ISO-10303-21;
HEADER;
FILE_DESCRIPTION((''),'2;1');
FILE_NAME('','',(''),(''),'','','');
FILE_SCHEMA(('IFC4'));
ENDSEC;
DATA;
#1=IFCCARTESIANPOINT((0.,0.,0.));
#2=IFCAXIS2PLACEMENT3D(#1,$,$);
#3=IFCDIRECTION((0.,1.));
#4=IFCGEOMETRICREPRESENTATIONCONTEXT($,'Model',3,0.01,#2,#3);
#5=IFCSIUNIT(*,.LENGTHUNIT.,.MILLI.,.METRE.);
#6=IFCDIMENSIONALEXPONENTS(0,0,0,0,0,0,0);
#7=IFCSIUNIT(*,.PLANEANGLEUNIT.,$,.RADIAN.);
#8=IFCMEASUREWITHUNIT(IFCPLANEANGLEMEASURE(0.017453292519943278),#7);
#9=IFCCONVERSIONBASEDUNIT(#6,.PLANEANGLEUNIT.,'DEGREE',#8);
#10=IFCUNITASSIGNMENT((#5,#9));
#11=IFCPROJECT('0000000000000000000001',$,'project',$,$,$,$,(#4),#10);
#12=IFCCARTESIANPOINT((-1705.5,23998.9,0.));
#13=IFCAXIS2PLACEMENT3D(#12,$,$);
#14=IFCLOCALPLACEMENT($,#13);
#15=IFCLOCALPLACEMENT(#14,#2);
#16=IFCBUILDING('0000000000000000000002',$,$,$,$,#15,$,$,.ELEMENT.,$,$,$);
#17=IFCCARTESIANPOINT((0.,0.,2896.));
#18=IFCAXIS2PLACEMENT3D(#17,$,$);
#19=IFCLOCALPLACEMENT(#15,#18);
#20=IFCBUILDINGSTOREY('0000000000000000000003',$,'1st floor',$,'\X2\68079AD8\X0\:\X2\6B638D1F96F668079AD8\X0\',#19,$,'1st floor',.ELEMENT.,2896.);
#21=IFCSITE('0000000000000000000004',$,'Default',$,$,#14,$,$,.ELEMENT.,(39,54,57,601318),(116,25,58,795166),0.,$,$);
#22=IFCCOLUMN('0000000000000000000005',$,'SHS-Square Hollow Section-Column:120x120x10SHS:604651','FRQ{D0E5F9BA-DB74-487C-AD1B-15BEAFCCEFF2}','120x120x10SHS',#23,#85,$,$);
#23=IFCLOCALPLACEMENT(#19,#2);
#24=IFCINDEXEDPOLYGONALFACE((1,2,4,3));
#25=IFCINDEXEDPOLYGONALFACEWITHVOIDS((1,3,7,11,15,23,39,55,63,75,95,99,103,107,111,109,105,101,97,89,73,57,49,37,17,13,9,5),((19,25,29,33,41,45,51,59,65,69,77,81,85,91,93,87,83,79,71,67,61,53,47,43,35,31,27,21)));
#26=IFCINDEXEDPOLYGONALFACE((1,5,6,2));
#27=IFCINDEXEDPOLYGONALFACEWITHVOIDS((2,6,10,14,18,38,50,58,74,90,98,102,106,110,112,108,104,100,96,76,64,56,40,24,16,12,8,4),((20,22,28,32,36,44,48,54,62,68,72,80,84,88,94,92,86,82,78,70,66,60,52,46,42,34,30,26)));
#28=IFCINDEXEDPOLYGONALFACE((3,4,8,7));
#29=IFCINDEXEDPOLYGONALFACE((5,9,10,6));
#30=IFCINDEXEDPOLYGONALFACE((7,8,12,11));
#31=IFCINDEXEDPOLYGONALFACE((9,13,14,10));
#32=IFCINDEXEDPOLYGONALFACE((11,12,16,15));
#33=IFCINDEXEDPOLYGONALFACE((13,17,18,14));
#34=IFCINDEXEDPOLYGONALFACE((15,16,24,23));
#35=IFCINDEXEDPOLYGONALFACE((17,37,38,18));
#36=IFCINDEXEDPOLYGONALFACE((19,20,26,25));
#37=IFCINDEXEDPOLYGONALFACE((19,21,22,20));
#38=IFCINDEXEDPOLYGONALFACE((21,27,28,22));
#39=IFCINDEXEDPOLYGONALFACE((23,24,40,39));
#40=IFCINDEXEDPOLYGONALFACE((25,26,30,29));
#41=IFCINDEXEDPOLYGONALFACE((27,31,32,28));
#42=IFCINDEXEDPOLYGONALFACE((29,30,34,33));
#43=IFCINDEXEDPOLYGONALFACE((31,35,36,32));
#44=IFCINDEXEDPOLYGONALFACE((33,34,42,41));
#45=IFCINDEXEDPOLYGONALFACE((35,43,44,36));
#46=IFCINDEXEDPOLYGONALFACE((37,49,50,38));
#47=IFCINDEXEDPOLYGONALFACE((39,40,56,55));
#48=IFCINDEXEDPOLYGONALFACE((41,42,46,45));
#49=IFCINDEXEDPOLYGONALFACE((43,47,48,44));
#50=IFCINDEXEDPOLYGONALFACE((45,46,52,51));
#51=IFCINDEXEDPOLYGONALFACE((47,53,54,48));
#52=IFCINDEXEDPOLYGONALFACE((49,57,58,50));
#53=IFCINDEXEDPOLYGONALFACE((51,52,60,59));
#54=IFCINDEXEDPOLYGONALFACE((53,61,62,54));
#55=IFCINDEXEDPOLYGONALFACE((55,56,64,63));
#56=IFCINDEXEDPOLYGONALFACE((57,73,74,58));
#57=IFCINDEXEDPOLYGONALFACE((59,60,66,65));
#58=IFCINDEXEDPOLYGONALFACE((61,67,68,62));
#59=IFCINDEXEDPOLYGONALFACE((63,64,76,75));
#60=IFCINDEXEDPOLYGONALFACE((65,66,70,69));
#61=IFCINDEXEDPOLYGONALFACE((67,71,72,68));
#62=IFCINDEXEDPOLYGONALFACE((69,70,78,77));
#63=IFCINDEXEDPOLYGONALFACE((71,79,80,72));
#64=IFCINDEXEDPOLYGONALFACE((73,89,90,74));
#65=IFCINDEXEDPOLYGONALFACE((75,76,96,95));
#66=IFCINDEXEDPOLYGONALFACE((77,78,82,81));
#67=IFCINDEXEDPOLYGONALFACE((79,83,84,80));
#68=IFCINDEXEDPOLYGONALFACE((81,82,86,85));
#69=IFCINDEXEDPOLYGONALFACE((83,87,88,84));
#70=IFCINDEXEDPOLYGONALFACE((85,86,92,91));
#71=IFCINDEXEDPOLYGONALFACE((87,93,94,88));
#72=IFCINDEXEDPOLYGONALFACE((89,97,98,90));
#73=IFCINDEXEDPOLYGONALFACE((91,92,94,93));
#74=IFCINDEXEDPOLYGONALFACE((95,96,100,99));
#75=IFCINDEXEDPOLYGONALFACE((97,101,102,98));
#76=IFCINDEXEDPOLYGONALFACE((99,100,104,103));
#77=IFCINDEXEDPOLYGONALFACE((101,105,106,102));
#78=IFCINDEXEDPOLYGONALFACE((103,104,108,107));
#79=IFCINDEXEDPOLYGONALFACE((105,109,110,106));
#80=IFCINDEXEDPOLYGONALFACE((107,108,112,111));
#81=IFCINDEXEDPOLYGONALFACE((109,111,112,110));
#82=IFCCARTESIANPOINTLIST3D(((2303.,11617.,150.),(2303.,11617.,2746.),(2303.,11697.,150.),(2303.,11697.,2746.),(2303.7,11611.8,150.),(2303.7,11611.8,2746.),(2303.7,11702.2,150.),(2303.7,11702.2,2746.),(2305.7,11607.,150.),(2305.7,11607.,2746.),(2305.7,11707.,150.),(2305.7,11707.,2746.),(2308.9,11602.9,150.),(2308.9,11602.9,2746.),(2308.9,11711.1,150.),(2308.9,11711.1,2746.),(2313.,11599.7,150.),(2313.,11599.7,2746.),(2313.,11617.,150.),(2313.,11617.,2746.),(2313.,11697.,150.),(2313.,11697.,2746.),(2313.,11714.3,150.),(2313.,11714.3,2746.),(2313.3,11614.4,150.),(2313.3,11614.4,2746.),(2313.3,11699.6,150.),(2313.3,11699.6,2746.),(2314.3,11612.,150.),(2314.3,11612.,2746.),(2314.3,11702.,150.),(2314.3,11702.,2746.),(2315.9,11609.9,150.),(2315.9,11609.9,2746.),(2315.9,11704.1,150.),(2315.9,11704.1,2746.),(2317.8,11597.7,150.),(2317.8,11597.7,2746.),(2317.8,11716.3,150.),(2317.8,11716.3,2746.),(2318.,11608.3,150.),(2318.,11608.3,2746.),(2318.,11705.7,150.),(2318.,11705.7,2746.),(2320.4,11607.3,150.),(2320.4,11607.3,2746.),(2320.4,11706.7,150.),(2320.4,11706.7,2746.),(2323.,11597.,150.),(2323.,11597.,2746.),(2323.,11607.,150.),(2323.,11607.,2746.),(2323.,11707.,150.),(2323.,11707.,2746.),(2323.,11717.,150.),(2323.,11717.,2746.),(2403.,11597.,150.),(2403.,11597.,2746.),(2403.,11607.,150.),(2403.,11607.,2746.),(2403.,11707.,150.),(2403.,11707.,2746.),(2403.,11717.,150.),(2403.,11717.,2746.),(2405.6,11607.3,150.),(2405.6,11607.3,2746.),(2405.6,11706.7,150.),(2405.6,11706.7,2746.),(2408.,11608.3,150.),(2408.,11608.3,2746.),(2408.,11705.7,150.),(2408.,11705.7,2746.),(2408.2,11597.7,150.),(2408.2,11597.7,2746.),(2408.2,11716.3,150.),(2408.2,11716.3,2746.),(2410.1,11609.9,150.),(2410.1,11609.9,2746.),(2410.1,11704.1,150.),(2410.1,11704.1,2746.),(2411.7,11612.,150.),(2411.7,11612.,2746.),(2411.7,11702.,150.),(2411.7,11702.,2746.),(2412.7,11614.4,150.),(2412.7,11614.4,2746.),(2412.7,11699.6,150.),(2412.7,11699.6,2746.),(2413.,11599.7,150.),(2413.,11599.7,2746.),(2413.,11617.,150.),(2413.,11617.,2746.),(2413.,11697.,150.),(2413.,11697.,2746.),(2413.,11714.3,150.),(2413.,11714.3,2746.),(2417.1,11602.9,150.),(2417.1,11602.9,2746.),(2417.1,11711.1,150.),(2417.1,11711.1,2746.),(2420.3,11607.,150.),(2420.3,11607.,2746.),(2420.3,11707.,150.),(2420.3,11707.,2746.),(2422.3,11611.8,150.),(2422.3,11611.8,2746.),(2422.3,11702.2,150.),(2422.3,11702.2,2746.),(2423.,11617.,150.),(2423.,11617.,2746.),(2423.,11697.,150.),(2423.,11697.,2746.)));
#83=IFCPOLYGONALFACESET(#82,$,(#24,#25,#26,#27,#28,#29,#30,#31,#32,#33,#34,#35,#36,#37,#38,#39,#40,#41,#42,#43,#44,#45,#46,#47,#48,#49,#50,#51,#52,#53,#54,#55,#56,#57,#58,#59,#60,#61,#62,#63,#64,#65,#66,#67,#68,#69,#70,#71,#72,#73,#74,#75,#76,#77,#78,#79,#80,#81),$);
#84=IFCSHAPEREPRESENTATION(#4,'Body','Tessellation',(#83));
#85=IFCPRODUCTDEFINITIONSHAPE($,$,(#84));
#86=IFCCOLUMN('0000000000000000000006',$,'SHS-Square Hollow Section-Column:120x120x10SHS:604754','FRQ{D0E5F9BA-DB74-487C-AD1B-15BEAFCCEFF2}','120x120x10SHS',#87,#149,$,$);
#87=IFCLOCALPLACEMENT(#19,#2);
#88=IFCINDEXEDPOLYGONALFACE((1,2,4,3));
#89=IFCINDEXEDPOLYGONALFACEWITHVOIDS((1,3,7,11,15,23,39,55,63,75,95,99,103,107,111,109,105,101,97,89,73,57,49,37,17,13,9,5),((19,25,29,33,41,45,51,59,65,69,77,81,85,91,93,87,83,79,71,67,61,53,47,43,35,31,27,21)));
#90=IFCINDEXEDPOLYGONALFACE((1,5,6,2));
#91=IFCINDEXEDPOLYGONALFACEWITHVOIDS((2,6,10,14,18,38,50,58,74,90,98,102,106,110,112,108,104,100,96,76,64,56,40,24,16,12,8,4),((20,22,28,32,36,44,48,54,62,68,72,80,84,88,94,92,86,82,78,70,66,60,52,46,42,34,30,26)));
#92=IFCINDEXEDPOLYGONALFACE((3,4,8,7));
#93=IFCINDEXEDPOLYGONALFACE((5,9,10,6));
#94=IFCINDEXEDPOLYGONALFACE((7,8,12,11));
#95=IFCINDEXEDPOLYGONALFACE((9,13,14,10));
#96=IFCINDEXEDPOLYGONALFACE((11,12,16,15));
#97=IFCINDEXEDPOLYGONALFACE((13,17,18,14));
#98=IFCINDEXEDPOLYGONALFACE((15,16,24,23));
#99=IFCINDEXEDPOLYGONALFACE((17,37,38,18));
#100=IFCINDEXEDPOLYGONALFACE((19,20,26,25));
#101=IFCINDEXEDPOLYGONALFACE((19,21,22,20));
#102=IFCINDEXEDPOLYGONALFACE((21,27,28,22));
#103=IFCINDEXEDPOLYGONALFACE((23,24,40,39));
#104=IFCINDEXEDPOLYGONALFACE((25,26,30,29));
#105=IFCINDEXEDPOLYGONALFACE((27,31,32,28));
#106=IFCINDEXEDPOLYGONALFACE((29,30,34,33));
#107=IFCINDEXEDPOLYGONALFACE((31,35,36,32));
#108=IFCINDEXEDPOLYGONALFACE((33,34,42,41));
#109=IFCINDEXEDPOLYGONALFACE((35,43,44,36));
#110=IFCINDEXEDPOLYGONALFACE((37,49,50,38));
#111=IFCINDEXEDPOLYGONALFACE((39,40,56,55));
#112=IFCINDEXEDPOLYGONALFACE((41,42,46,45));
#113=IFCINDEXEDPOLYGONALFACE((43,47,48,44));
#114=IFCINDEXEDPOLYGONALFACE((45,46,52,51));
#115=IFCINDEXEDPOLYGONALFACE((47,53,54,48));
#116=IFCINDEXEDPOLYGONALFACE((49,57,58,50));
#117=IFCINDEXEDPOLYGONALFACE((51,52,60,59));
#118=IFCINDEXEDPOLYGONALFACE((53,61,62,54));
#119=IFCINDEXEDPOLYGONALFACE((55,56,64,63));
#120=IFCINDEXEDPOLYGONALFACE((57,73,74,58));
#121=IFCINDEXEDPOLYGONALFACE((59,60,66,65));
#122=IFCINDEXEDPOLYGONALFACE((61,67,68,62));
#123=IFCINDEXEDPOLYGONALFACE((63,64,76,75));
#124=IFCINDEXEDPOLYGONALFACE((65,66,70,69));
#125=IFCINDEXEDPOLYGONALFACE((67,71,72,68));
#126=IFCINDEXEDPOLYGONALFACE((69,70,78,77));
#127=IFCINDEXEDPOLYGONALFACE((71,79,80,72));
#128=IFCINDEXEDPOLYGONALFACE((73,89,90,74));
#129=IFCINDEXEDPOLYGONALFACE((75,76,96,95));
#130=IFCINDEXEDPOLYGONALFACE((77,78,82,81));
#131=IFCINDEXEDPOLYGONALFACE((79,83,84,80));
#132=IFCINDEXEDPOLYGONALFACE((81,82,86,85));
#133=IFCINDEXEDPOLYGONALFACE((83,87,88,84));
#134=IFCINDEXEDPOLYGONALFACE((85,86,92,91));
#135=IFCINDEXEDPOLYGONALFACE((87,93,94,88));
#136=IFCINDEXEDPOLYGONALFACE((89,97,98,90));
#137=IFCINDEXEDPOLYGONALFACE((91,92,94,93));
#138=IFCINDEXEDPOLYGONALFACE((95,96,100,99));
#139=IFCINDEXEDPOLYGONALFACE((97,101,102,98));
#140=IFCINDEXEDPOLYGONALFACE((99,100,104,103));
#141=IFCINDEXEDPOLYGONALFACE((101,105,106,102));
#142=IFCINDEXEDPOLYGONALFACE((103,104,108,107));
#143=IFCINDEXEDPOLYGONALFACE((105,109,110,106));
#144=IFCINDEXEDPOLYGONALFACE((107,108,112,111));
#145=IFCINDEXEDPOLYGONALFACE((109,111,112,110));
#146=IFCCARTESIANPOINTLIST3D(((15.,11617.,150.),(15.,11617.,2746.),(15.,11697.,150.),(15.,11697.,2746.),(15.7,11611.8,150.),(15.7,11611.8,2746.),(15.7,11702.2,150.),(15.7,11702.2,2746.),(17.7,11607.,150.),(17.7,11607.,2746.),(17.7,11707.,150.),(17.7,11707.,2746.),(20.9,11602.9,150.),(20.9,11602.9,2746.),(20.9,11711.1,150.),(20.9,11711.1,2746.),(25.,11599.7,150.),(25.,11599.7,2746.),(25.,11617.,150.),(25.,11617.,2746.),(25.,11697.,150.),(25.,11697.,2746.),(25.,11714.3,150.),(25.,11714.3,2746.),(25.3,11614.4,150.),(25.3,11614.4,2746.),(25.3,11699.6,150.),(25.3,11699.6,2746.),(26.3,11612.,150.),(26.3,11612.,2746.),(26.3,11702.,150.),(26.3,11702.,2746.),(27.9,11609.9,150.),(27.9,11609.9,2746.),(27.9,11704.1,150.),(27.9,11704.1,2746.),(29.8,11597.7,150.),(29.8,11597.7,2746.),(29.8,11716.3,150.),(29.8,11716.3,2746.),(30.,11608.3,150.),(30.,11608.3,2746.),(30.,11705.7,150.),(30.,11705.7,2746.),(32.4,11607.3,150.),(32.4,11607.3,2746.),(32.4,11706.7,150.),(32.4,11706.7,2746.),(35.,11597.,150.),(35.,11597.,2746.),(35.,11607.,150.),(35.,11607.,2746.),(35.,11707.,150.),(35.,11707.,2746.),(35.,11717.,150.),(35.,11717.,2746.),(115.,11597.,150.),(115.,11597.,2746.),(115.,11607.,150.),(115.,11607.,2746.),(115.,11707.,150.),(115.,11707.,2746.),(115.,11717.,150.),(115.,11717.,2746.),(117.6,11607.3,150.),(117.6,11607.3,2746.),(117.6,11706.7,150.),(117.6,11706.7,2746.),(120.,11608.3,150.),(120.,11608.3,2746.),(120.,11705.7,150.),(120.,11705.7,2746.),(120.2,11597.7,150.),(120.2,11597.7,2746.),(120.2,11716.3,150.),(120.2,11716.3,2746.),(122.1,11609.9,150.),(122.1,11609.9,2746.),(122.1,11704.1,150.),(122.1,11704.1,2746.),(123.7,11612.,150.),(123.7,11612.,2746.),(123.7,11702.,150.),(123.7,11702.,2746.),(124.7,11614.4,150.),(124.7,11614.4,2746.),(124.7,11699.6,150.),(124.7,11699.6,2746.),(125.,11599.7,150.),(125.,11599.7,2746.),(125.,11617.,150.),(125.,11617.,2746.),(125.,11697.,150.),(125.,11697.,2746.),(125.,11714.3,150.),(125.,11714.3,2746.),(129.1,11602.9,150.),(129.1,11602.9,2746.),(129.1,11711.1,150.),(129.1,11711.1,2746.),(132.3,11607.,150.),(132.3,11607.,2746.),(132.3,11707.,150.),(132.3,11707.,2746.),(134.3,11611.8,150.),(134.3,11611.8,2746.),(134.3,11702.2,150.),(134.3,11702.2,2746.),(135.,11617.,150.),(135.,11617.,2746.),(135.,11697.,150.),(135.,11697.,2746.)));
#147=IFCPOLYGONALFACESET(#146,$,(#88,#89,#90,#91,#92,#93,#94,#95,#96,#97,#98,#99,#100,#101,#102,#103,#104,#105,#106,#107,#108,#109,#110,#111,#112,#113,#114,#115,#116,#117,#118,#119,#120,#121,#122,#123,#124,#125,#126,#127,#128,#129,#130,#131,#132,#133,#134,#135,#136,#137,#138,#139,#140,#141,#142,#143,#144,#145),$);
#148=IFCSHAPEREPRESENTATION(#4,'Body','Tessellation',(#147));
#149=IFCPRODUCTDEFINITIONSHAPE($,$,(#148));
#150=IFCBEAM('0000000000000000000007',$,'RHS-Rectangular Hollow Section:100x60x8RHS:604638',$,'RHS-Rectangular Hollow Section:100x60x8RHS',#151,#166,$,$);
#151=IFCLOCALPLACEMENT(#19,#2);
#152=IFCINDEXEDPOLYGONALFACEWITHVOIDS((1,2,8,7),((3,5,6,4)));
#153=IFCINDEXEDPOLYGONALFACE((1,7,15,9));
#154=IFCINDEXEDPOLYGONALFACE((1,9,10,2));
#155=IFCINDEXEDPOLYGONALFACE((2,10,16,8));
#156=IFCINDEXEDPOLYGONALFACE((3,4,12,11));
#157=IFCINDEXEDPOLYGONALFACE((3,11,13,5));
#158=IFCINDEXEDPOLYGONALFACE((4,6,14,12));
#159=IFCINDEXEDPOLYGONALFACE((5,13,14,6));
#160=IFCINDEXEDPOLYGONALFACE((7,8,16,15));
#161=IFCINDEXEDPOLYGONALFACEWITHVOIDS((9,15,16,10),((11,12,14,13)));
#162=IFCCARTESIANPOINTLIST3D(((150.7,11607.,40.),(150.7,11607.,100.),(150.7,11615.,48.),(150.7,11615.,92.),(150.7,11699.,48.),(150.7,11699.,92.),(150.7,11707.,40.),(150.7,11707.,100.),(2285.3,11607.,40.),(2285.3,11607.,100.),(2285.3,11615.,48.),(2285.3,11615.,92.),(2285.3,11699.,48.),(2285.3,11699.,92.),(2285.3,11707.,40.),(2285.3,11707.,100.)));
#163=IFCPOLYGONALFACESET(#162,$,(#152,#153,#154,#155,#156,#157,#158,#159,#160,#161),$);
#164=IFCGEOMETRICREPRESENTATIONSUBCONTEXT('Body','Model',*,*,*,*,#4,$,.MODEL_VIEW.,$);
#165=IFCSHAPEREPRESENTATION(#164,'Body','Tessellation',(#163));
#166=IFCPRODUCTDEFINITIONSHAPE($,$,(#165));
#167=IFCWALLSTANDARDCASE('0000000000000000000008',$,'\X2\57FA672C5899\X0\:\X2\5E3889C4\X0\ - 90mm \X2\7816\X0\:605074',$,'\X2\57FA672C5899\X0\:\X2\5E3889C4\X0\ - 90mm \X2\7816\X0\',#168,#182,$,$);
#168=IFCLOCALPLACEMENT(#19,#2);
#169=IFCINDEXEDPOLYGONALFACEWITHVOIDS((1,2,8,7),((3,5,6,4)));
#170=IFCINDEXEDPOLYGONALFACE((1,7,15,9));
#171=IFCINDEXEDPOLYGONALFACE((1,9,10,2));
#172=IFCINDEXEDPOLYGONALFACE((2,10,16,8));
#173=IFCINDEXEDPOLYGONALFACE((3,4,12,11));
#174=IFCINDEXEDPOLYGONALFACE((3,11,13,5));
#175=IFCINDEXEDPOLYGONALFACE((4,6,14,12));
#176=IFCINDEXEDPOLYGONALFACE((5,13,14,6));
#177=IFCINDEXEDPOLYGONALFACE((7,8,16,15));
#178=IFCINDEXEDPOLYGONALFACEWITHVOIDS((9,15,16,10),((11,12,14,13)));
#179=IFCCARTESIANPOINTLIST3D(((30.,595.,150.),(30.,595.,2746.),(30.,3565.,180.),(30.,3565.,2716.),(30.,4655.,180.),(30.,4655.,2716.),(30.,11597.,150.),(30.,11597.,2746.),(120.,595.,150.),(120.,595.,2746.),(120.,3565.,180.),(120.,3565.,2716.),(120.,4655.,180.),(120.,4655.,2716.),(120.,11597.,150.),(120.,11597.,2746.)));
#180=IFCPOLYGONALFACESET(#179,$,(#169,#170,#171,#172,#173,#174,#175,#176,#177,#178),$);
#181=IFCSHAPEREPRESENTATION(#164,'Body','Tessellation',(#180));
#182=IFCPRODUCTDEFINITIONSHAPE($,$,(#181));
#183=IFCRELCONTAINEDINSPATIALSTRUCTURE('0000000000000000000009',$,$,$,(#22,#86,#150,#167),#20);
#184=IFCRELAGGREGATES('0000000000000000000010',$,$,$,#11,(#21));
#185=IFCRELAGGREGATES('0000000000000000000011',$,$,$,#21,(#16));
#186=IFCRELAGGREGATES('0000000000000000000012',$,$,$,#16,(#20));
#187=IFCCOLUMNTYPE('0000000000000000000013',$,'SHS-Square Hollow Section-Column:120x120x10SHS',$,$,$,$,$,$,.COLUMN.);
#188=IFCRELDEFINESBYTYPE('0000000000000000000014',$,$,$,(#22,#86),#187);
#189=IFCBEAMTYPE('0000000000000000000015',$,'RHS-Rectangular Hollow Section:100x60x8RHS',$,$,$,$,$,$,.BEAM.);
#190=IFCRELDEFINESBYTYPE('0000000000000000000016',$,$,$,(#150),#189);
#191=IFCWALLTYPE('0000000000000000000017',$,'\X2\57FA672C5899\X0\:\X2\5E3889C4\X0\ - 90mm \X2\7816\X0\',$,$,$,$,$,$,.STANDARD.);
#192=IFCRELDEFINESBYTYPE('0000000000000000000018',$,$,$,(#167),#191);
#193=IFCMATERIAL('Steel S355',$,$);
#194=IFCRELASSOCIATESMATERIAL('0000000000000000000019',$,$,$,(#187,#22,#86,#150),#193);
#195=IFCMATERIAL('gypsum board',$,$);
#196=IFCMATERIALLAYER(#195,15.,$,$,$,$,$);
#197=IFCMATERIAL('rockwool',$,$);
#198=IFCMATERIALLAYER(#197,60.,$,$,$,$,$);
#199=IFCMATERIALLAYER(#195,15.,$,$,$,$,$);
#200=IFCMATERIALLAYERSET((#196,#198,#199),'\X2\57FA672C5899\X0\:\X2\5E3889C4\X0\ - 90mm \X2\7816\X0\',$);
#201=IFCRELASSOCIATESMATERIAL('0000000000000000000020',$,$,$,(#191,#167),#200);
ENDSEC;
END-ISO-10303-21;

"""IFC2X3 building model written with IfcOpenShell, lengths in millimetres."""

from ifc_helpers import new_model, entity, si_unit, converted_unit, direction, frame, frame_2d, origin, origin_2d, place, context, subcontext, project, spatial, rectangle, hollow_rectangle, extrude, boolean, clip, halfspace, material, layer, layer_set, layer_usage, type_object, element, save


model = new_model("IFC2X3")

# Units and contexts
model_context = context("Model", 3, precision=0.01, world=origin(), true_north=direction((0.0, 1.0)))
body_context = subcontext(model_context, "Body", "Model", "MODEL_VIEW")
ifc_project = project(units=[si_unit("LENGTHUNIT", "METRE", prefix="MILLI"), converted_unit("PLANEANGLEUNIT", "DEGREE", entity("IfcPlaneAngleMeasure", 0.017453292519943278), si_unit("PLANEANGLEUNIT", "RADIAN"), dimensions=[0, 0, 0, 0, 0, 0, 0])], contexts=[model_context])

# Site, building, storey
site_placement = place(None, frame((-1705.5, 23998.9, 0.0)))
site = spatial("IfcSite", under=ifc_project, at=site_placement, Name="Default", CompositionType="ELEMENT", RefLatitude=(39, 54, 57, 601318), RefLongitude=(116, 25, 58, 795166), RefElevation=0.0)
building_placement = place(site_placement, origin())
building = spatial("IfcBuilding", under=site, at=building_placement, CompositionType="ELEMENT")
storey_placement = place(building_placement, frame((0.0, 0.0, 2896.0)))
storey = spatial("IfcBuildingStorey", under=building, at=storey_placement, Name="1st floor", ObjectType="标高:正负零标高", LongName="1st floor", CompositionType="ELEMENT", Elevation=2896.0)

# Shared definitions
ifc_material_1 = material(Name="Steel S355")

# Columns
column_type_1 = type_object("IfcColumnType", Name="SHS-Square Hollow Section-Column:120x120x10SHS", PredefinedType="COLUMN", material=ifc_material_1)
column_1_placement = place(storey_placement, frame((2363.0, 11657.0, 2830.9), z_axis=(0.0, 0.0, 1.0), x_axis=(0.0, -1.0, 0.0)))
element("IfcColumn", 1, at=column_1_placement, inside=storey, type_object=column_type_1, material=ifc_material_1, Name="SHS-Square Hollow Section-Column:120x120x10SHS:604651", Description="FRQ{D0E5F9BA-DB74-487C-AD1B-15BEAFCCEFF2}", ObjectType="120x120x10SHS", context=model_context, shape_type="Clipping", body=[
    clip(clip(extrude(hollow_rectangle(XDim=120.0, YDim=120.0, WallThickness=10.0, InnerFilletRadius=10.0, OuterFilletRadius=20.0, at=origin_2d()), origin(), (0.0, 0.0, -1.0), 2765.7), halfspace(frame((11657.0, -2363.0, -84.9), z_axis=(0.0, 0.0, -1.0), x_axis=(0.0, -1.0, 0.0)), True)), halfspace(frame((11657.0, -2363.0, -2680.9), z_axis=(0.0, 0.0, 1.0), x_axis=(0.0, 1.0, 0.0)), True)),
])
column_2_placement = place(storey_placement, frame((75.0, 11657.0, 2830.9), z_axis=(0.0, 0.0, 1.0), x_axis=(0.0, -1.0, 0.0)))
element("IfcColumn", 2, at=column_2_placement, inside=storey, type_object=column_type_1, material=ifc_material_1, Name="SHS-Square Hollow Section-Column:120x120x10SHS:604754", Description="FRQ{D0E5F9BA-DB74-487C-AD1B-15BEAFCCEFF2}", ObjectType="120x120x10SHS", context=model_context, shape_type="Clipping", body=[
    clip(clip(extrude(hollow_rectangle(XDim=120.0, YDim=120.0, WallThickness=10.0, InnerFilletRadius=10.0, OuterFilletRadius=20.0, at=origin_2d()), origin(), (0.0, 0.0, -1.0), 2765.7), halfspace(frame((11657.0, -75.0, -84.9), z_axis=(0.0, 0.0, -1.0), x_axis=(0.0, -1.0, 0.0)), True)), halfspace(frame((11657.0, -75.0, -2680.9), z_axis=(0.0, 0.0, 1.0), x_axis=(0.0, 1.0, 0.0)), True)),
])

# Beam
beam_type_1 = type_object("IfcBeamType", Name="RHS-Rectangular Hollow Section:100x60x8RHS", PredefinedType="BEAM")
beam_1_placement = place(storey_placement, frame((150.7, 11707.0, 70.0)))
element("IfcBeam", 3, at=beam_1_placement, inside=storey, type_object=beam_type_1, material=ifc_material_1, Name="RHS-Rectangular Hollow Section:100x60x8RHS:604638", ObjectType="RHS-Rectangular Hollow Section:100x60x8RHS", context=body_context, shape_type="SweptSolid", body=[
    boolean("DIFFERENCE", extrude(rectangle(XDim=60.0, YDim=100.0, at=frame_2d((0.0, 0.0), x_axis=(1.0, 0.0))), frame((0.0, -50.0, 0.0), z_axis=(1.0, 0.0, 0.0), x_axis=(0.0, 0.0, -1.0)), (0.0, 0.0, 1.0), 2134.6), extrude(rectangle(XDim=44.0, YDim=84.0, at=frame_2d((0.0, 0.0), x_axis=(0.0, 1.0))), frame((2134.6, -50.0, 0.0), z_axis=(-1.0, 0.0, 0.0), x_axis=(0.0, 1.0, 0.0)), (0.0, 0.0, 1.0), 2134.6)),
])

# Shared definitions
ifc_material_2 = material(Name="gypsum board")
ifc_layer_1 = layer(ifc_material_2, 15.0)
ifc_material_3 = material(Name="rockwool")
ifc_layer_2 = layer(ifc_material_3, 60.0)
ifc_layer_3 = layer(ifc_material_2, 15.0)
ifc_layer_set = layer_set([ifc_layer_1, ifc_layer_2, ifc_layer_3], Name="基本墙:常规 - 90mm 砖")
wall_type = type_object("IfcWallType", Name="基本墙:常规 - 90mm 砖", PredefinedType="STANDARD", material=ifc_layer_set)

# Wall, opening
ifc_layer_usage_1 = layer_usage(ifc_layer_set, "AXIS2", "NEGATIVE", 45.0)
wall_1_placement = place(storey_placement, frame((75.0, 11597.0, 150.0), z_axis=(0.0, 0.0, 1.0), x_axis=(0.0, -1.0, 0.0)))
wall_1 = element("IfcWallStandardCase", 4, at=wall_1_placement, inside=storey, type_object=wall_type, material=ifc_layer_usage_1, Name="基本墙:常规 - 90mm 砖:605074", ObjectType="基本墙:常规 - 90mm 砖", context=body_context, shape_type="SweptSolid", body=[
    extrude(rectangle(XDim=11002.0, YDim=90.0, at=frame_2d((5501.0, 0.0), x_axis=(-1.0, 0.0))), origin(), (0.0, 0.0, 1.0), 2596.0),
])
opening_1_placement = place(wall_1_placement, origin())
element("IfcOpeningElement", 5, at=opening_1_placement, cuts=wall_1, ObjectType="Opening", context=body_context, shape_type="SweptSolid", body=[
    extrude(rectangle(XDim=2536.0, YDim=1090.0, at=frame_2d((0.0, 0.0), x_axis=(0.0, 1.0))), frame((7487.0, 45.0, 1298.0), z_axis=(0.0, -1.0, 0.0), x_axis=(-1.0, 0.0, 0.0)), (0.0, 0.0, 1.0), 90.0),
])

save(model, "model.ifc")
